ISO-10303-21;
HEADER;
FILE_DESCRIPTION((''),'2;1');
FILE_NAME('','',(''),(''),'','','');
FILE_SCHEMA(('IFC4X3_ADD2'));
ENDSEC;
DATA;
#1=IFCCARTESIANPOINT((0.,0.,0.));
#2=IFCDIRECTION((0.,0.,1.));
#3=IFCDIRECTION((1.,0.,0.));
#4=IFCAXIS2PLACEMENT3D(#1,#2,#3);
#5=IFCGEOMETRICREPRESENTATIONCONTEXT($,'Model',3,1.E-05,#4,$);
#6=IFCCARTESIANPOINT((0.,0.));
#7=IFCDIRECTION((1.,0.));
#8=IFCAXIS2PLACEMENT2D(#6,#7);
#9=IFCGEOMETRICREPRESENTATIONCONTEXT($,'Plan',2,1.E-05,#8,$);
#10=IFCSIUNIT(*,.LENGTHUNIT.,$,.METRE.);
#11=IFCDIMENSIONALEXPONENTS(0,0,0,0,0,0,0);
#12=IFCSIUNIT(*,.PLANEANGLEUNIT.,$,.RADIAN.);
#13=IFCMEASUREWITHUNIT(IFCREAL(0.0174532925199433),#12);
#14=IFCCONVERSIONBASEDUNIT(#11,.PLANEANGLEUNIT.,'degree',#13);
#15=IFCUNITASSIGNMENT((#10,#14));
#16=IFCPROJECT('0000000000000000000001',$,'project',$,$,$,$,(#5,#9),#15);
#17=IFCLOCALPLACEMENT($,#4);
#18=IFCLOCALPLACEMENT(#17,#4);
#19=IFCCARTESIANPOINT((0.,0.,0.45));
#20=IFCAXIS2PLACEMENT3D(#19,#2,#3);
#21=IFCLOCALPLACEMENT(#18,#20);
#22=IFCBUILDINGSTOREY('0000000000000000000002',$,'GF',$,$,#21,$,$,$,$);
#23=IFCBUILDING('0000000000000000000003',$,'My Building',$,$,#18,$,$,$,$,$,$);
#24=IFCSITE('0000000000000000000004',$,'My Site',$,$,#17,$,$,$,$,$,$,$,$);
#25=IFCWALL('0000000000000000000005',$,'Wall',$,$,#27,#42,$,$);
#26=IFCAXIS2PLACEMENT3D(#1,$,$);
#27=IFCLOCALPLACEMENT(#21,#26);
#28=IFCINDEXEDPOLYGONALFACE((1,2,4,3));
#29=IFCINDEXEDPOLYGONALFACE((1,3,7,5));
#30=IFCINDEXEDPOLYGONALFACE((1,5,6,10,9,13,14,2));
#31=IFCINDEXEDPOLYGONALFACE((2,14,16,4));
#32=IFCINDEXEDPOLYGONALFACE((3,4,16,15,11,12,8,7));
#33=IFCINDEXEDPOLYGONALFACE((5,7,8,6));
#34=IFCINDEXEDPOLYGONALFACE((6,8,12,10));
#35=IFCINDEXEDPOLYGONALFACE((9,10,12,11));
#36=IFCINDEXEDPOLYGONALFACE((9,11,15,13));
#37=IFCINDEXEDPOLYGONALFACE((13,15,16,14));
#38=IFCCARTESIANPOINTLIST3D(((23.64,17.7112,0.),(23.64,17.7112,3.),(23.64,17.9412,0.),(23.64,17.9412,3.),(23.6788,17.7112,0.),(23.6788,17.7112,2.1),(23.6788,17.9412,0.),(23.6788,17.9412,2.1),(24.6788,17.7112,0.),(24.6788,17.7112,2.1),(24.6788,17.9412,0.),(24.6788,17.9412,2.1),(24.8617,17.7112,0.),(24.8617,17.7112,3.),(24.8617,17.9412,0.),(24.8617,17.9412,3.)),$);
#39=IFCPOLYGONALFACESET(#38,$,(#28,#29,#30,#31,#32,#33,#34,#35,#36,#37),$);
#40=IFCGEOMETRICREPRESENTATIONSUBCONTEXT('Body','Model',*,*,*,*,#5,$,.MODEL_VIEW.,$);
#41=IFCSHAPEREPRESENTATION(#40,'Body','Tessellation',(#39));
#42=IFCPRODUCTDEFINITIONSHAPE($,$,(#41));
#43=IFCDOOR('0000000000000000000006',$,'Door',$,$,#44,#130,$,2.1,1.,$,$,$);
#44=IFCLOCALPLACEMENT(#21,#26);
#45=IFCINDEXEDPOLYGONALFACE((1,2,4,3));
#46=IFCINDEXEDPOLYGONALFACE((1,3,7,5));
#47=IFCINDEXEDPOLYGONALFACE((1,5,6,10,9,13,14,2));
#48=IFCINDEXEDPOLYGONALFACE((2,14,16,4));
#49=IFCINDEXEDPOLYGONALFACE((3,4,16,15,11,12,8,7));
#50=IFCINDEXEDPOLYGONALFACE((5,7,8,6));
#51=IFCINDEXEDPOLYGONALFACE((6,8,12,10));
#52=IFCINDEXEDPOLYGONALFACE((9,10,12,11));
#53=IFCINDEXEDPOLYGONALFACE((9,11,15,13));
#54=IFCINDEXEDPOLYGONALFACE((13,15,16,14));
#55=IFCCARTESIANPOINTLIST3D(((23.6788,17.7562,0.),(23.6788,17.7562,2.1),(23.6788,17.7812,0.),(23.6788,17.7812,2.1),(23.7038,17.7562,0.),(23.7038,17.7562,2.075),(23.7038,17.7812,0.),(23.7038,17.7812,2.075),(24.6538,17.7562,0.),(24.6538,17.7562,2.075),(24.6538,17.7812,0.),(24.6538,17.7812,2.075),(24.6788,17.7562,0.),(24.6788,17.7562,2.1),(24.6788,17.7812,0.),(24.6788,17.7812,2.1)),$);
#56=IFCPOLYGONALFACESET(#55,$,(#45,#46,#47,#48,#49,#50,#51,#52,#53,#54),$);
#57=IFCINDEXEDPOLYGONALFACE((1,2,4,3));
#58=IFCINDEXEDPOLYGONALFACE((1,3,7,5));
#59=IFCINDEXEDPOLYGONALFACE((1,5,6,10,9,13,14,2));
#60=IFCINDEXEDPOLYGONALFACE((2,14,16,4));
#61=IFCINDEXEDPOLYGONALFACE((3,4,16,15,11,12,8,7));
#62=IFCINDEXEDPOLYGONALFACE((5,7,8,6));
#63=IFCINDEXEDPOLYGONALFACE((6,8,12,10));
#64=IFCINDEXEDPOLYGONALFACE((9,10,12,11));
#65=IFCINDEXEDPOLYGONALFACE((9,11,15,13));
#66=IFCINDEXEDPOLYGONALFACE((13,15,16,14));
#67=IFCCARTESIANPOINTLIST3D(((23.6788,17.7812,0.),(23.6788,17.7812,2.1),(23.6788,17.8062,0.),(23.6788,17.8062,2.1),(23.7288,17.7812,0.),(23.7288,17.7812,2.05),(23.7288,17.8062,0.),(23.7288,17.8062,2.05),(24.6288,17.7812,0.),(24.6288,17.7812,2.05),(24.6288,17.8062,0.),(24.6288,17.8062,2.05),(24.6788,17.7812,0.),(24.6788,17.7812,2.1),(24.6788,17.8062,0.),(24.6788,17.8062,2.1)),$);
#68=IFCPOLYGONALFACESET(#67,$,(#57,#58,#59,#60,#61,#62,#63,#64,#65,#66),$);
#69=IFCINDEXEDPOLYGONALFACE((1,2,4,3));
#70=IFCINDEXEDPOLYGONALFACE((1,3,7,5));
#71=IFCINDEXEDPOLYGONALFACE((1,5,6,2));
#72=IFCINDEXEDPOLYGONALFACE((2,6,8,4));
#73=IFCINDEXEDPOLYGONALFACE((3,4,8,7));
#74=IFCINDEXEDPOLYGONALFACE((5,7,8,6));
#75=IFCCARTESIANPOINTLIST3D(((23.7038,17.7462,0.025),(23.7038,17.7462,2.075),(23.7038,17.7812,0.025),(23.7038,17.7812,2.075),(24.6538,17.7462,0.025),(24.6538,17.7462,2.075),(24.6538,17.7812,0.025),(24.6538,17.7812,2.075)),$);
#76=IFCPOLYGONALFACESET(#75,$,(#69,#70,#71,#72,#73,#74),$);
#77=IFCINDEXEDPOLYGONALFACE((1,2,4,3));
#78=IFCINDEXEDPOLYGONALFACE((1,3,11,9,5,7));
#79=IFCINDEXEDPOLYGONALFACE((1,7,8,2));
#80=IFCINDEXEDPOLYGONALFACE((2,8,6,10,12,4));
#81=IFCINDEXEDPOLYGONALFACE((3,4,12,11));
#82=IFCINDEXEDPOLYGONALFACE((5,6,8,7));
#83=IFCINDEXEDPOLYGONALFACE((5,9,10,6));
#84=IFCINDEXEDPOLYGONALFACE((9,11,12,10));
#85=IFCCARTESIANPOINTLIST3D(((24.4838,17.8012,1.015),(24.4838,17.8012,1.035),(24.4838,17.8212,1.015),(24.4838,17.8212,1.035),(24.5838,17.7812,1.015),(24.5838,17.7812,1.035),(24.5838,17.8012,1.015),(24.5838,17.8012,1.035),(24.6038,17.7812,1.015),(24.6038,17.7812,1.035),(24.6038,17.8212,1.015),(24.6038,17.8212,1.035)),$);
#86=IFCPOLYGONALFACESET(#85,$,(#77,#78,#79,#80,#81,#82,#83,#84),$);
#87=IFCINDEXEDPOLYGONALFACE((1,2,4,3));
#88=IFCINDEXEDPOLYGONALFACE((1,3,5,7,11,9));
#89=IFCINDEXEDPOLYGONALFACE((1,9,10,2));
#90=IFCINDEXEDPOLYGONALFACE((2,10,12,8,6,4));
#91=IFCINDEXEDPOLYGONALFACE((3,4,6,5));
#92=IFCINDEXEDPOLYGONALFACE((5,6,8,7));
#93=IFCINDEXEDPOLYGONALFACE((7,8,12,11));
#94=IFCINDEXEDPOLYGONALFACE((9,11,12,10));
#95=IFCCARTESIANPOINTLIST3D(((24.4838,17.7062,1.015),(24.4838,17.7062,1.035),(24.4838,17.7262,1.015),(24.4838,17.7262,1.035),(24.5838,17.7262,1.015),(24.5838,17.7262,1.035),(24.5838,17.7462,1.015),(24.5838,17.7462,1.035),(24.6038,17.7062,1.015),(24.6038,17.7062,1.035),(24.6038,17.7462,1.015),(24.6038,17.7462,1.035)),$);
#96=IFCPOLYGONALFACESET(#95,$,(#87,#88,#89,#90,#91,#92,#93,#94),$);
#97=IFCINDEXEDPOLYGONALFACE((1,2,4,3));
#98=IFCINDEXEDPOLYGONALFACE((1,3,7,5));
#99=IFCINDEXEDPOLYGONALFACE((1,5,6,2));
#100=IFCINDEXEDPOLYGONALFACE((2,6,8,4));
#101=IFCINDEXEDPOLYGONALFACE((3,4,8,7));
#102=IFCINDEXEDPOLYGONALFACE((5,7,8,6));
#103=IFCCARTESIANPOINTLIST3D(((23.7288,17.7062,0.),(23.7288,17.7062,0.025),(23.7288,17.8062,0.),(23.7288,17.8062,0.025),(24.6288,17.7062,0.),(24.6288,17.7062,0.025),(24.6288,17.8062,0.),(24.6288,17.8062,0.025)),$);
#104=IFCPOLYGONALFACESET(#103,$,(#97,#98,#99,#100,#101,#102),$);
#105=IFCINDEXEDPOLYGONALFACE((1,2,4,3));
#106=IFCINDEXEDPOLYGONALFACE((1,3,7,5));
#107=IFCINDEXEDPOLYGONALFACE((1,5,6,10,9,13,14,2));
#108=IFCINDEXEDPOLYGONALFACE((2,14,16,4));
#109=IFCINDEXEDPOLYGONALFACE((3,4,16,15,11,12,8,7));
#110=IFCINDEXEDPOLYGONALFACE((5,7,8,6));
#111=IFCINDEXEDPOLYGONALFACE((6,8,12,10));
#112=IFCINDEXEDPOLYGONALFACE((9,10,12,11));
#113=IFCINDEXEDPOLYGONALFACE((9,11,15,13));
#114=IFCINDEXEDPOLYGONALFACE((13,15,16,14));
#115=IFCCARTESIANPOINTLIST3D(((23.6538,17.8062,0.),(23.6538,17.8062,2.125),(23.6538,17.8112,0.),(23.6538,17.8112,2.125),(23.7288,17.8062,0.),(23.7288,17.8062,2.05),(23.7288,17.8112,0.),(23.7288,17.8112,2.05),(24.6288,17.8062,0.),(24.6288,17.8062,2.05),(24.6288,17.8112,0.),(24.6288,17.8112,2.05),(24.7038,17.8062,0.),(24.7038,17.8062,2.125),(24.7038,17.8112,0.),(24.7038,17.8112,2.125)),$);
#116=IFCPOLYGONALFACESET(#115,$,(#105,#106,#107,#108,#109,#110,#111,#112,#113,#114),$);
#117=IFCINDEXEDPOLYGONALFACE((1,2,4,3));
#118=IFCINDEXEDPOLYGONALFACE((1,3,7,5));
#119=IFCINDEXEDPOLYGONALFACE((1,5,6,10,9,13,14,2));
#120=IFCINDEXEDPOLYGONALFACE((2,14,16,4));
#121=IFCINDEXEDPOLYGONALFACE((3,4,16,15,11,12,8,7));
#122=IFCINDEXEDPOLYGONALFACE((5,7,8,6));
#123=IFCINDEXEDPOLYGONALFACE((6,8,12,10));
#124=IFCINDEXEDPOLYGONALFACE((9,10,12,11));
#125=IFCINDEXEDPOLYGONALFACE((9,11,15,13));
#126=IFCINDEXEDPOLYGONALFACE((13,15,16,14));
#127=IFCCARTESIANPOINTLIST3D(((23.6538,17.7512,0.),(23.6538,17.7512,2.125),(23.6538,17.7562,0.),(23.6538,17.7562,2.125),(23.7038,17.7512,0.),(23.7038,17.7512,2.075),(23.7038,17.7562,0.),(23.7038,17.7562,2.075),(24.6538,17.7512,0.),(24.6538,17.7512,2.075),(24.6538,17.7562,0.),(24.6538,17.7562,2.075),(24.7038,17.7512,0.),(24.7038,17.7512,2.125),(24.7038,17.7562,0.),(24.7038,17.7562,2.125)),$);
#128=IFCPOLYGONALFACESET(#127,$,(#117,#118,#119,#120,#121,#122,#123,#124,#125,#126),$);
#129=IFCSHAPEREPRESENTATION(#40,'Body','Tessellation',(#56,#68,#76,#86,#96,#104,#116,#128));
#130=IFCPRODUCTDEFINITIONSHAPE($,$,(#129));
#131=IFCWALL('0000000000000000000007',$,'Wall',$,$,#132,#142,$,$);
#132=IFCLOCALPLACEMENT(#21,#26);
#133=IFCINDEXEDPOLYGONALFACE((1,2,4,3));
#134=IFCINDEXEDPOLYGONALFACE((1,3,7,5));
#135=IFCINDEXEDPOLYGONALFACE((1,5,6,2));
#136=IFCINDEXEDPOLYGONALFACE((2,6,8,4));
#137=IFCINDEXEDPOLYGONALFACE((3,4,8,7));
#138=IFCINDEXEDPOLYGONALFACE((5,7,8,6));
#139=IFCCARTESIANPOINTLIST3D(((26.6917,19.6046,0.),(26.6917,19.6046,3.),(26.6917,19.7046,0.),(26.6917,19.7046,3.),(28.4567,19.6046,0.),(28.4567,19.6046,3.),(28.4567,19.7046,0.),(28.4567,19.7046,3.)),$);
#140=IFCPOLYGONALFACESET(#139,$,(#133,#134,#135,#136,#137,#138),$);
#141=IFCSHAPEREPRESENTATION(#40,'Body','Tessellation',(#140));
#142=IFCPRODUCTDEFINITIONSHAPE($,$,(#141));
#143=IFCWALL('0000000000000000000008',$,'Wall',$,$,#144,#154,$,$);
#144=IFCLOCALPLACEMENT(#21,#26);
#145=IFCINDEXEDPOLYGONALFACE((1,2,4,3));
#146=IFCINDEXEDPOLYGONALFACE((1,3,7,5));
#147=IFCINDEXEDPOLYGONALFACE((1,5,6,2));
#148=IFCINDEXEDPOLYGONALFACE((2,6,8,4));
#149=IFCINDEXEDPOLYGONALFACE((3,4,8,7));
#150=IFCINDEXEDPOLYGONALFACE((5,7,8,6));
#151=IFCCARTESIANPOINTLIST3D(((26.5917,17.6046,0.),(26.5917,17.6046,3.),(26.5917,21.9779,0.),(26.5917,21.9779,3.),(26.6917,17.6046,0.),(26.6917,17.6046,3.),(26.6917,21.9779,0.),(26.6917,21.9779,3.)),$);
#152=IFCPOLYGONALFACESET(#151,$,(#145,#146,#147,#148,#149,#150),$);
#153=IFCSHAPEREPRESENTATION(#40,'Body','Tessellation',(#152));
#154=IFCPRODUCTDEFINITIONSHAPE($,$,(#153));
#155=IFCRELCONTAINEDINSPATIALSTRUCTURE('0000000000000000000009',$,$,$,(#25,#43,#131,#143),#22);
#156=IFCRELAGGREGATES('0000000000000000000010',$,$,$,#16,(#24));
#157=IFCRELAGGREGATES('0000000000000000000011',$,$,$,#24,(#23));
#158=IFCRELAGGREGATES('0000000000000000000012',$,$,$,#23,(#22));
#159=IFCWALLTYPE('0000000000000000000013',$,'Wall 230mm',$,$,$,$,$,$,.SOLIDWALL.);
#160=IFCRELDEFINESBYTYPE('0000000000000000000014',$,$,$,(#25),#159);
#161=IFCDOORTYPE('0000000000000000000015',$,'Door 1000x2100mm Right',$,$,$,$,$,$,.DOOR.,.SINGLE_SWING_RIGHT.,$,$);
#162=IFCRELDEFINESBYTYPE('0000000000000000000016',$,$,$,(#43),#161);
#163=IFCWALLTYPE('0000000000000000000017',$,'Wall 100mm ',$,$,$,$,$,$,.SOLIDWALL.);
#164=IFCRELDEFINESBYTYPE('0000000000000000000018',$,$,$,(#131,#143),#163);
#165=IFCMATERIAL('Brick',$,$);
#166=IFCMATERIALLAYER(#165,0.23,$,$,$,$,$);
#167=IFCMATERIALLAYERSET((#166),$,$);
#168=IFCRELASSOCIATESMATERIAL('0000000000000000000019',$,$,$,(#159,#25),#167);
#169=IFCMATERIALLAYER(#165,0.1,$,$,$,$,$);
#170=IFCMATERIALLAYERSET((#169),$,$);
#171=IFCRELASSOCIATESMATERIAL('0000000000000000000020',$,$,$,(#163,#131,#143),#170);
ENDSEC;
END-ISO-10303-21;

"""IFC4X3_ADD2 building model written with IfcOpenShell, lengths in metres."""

from ifc_helpers import new_model, entity, si_unit, converted_unit, frame, origin_with_axes, origin_2d_with_axis, place, context, subcontext, project, spatial, line, indexed_curve, outline, extrude, shape, source, transform, mapped, material, layer, layer_set, layer_usage, type_object, type_shapes, element, fill, save


model = new_model("IFC4X3_ADD2")

# Units and contexts
model_context = context("Model", 3, precision=1e-05, world=origin_with_axes())
plan_context = context("Plan", 2, precision=1e-05, world=origin_2d_with_axis())
body_context_1 = subcontext(model_context, "Body", "Model", "MODEL_VIEW")
body_context_2 = subcontext(plan_context, "Body", "Plan", "PLAN_VIEW")
ifc_project = project(units=[si_unit("LENGTHUNIT", "METRE"), converted_unit("PLANEANGLEUNIT", "degree", entity("IfcReal", 0.0174532925199433), si_unit("PLANEANGLEUNIT", "RADIAN"), dimensions=[0, 0, 0, 0, 0, 0, 0])], contexts=[model_context, plan_context])

# Site, building, storey
site_placement = place(None, origin_with_axes())
site = spatial("IfcSite", under=ifc_project, at=site_placement, Name="My Site")
building_placement = place(site_placement, origin_with_axes())
building = spatial("IfcBuilding", under=site, at=building_placement, Name="My Building")
storey_placement = place(building_placement, frame((0.0, 0.0, 0.45), z_axis=(0.0, 0.0, 1.0), x_axis=(1.0, 0.0, 0.0)))
storey = spatial("IfcBuildingStorey", under=building, at=storey_placement, Name="GF")

# Shared definitions
ifc_material_1 = material(Name="Brick")
ifc_layer_1 = layer(ifc_material_1, 0.23)
ifc_layer_set_1 = layer_set([ifc_layer_1])
wall_type_1 = type_object("IfcWallType", Name="Wall 230mm", PredefinedType="SOLIDWALL", material=ifc_layer_set_1)

# Wall, opening, door
ifc_layer_usage_1 = layer_usage(ifc_layer_set_1, "AXIS2", "POSITIVE", 0.0)
wall_1_placement = place(storey_placement, frame((23.64, 17.7112, 0.0), z_axis=(0.0, 0.0, 1.0), x_axis=(1.0, 0.0, 0.0)))
wall_1 = element("IfcWall", 1, at=wall_1_placement, inside=storey, type_object=wall_type_1, material=ifc_layer_usage_1, Name="Wall", context=body_context_1, shape_type="SweptSolid", body=[
    extrude(outline(indexed_curve([(0.0, 0.0), (0.0, 0.23), (1.2216, 0.23), (1.2216, 0.0), (0.0, 0.0)], self_intersect=False)), origin_with_axes(), (0.0, 0.0, 1.0), 3.0),
])
shared_shape_1 = source(origin_with_axes(), body_context_1, "Body", "SweptSolid", [
    extrude(outline(indexed_curve([(0.0, 0.0), (1.0, 0.0), (1.0, 2.1), (0.0, 2.1)], segments=[line(1, 2, 3, 4, 1)])), frame((0.0, -0.6, 0.0), z_axis=(0.0, -1.0, 0.0), x_axis=(1.0, 0.0, 0.0)), (0.0, 0.0, -1.0), 1.2),
])
opening_1_placement = place(wall_1_placement, frame((1.0387, 0.095, 0.0), z_axis=(0.0, 0.0, 1.0), x_axis=(-1.0, 0.0, 0.0)))
opening_1 = element("IfcOpeningElement", 2, at=opening_1_placement, cuts=wall_1, PredefinedType="OPENING", context=body_context_1, shape_type="MappedRepresentation", body=[
    mapped(shared_shape_1, transform((0.0, 0.0, 0.0), x_axis=(1.0, 0.0, 0.0), y_axis=(0.0, 1.0, 0.0), z_axis=(0.0, 0.0, 1.0), scale=1.0)),
])
door_type = type_object("IfcDoorType", Name="Door 1000x2100mm Right", OperationType="SINGLE_SWING_RIGHT", PredefinedType="DOOR")
shared_shape_2 = source(origin_with_axes(), body_context_1, "Body", "SweptSolid", [
    extrude(outline(indexed_curve([(0.0, 0.0), (0.0, 2.1), (1.0, 2.1), (1.0, 0.0), (0.975, 0.0), (0.975, 2.075), (0.025, 2.075), (0.025, 0.0)], segments=[line(1, 2, 3, 4, 5, 6, 7, 8, 1)])), frame((0.0, 0.025, 0.0), z_axis=(0.0, -1.0, 0.0), x_axis=(1.0, 0.0, 0.0)), (0.0, 0.0, -1.0), 0.025),
    extrude(outline(indexed_curve([(0.0, 0.0), (0.0, 2.1), (1.0, 2.1), (1.0, 0.0), (0.95, 0.0), (0.95, 2.05), (0.05, 2.05), (0.05, 0.0)], segments=[line(1, 2, 3, 4, 5, 6, 7, 8, 1)])), frame((0.0, 0.0, 0.0), z_axis=(0.0, -1.0, 0.0), x_axis=(1.0, 0.0, 0.0)), (0.0, 0.0, -1.0), 0.025),
    extrude(outline(indexed_curve([(0.0, 0.0), (0.95, 0.0), (0.95, 0.035), (0.0, 0.035)], segments=[line(1, 2, 3, 4, 1)])), frame((0.025, 0.025, 0.025), z_axis=(0.0, 0.0, 1.0), x_axis=(1.0, 0.0, 0.0)), (0.0, 0.0, 1.0), 2.05),
    extrude(outline(indexed_curve([(0.0, 0.0), (0.0, -0.04), (0.12, -0.04), (0.12, -0.02), (0.02, -0.02), (0.02, 0.0)], segments=[line(1, 2, 3, 4, 5, 6, 1)])), frame((0.075, 0.025, 1.015), z_axis=(0.0, 0.0, 1.0), x_axis=(1.0, 0.0, 0.0)), (0.0, 0.0, 1.0), 0.02),
    extrude(outline(indexed_curve([(0.0, 0.0), (0.0, 0.04), (0.12, 0.04), (0.12, 0.02), (0.02, 0.02), (0.02, 0.0)], segments=[line(1, 2, 3, 4, 5, 6, 1)])), frame((0.075, 0.06, 1.015), z_axis=(0.0, 0.0, 1.0), x_axis=(1.0, 0.0, 0.0)), (0.0, 0.0, 1.0), 0.02),
    extrude(outline(indexed_curve([(0.0, 0.0), (0.9, 0.0), (0.9, 0.1), (0.0, 0.1)], segments=[line(1, 2, 3, 4, 1)])), frame((0.05, 0.0, 0.0), z_axis=(0.0, 0.0, 1.0), x_axis=(1.0, 0.0, 0.0)), (0.0, 0.0, 1.0), 0.025),
    extrude(outline(indexed_curve([(0.0, 0.0), (0.0, 2.125), (1.05, 2.125), (1.05, 0.0), (0.975, 0.0), (0.975, 2.05), (0.075, 2.05), (0.075, 0.0)], segments=[line(1, 2, 3, 4, 5, 6, 7, 8, 1)])), frame((-0.025, -0.005, 0.0), z_axis=(0.0, -1.0, 0.0), x_axis=(1.0, 0.0, 0.0)), (0.0, 0.0, -1.0), 0.005),
    extrude(outline(indexed_curve([(0.0, 0.0), (0.0, 2.125), (1.05, 2.125), (1.05, 0.0), (1.0, 0.0), (1.0, 2.075), (0.05, 2.075), (0.05, 0.0)], segments=[line(1, 2, 3, 4, 5, 6, 7, 8, 1)])), frame((-0.025, 0.05, 0.0), z_axis=(0.0, -1.0, 0.0), x_axis=(1.0, 0.0, 0.0)), (0.0, 0.0, -1.0), 0.005),
])
shared_shape_3 = source(origin_with_axes(), body_context_2, "Body", "Curve2D", [
    entity("IfcIndexedPolyCurve", entity("IfcCartesianPointList2D", [[0.0, 0.0], [0.0, 0.05], [0.025, 0.05], [0.025, 0.025], [0.05, 0.025], [0.05, 0.0]]), [entity("IfcLineIndex", [1, 2, 3, 4, 5, 6, 1])]),
    entity("IfcIndexedPolyCurve", entity("IfcCartesianPointList2D", [[1.0, 0.0], [1.0, 0.05], [0.975, 0.05], [0.975, 0.025], [0.95, 0.025], [0.95, 0.0]]), [entity("IfcLineIndex", [1, 2, 3, 4, 5, 6, 1])]),
    entity("IfcTrimmedCurve", entity("IfcEllipse", entity("IfcAxis2Placement2D", entity("IfcCartesianPoint", [0.94, 0.05]), entity("IfcDirection", [1.0, 0.0])), 0.915, 0.95), [entity("IfcCartesianPoint", [0.94, 1.0])], [entity("IfcCartesianPoint", [0.025, 0.05])], True, "CARTESIAN"),
    entity("IfcIndexedPolyCurve", entity("IfcCartesianPointList2D", [[0.975, 0.05], [0.94, 0.05], [0.94, 1.0], [0.975, 1.0]]), [entity("IfcLineIndex", [1, 2, 3, 4, 1])]),
])
type_shapes(door_type, [shared_shape_2, shared_shape_3])
door_placement = place(opening_1_placement, origin_with_axes())
door = element("IfcDoor", 3, at=door_placement, inside=storey, type_object=door_type, Name="Door", OverallHeight=2.1, OverallWidth=1.0, shapes=[
    shape(body_context_1, "Body", "MappedRepresentation", [mapped(shared_shape_2, transform((0.0, 0.0, 0.0), x_axis=(1.0, 0.0, 0.0), y_axis=(0.0, 1.0, 0.0), z_axis=(0.0, 0.0, 1.0), scale=1.0))]),
    shape(body_context_2, "Body", "MappedRepresentation", [mapped(shared_shape_3, transform((0.0, 0.0, 0.0), x_axis=(1.0, 0.0, 0.0), y_axis=(0.0, 1.0, 0.0), z_axis=(0.0, 0.0, 1.0), scale=1.0))]),
])
fill(opening_1, door)

# Walls
ifc_layer_2 = layer(ifc_material_1, 0.1)
ifc_layer_set_2 = layer_set([ifc_layer_2])
ifc_layer_usage_2 = layer_usage(ifc_layer_set_2, "AXIS2", "POSITIVE", 0.0)
wall_type_2 = type_object("IfcWallType", Name="Wall 100mm ", PredefinedType="SOLIDWALL", material=ifc_layer_set_2)
wall_2_placement = place(storey_placement, frame((26.6917, 19.6046, 0.0), z_axis=(0.0, 0.0, 1.0), x_axis=(1.0, 0.0, 0.0)))
element("IfcWall", 4, at=wall_2_placement, inside=storey, type_object=wall_type_2, material=ifc_layer_usage_2, Name="Wall", context=body_context_1, shape_type="SweptSolid", body=[
    extrude(outline(indexed_curve([(0.0, 0.0), (0.0, 0.1), (1.765, 0.1), (1.765, 0.0), (0.0, 0.0)], self_intersect=False)), origin_with_axes(), (0.0, 0.0, 1.0), 3.0),
])
ifc_layer_usage_3 = layer_usage(ifc_layer_set_2, "AXIS2", "POSITIVE", 0.0)
wall_3_placement = place(storey_placement, frame((26.6917, 17.6046, 0.0), z_axis=(0.0, 0.0, 1.0), x_axis=(0.0, 1.0, 0.0)))
element("IfcWall", 5, at=wall_3_placement, inside=storey, type_object=wall_type_2, material=ifc_layer_usage_3, Name="Wall", context=body_context_1, shape_type="SweptSolid", body=[
    extrude(outline(indexed_curve([(0.0, 0.0), (0.0, 0.1), (4.3733, 0.1), (4.3733, 0.0), (0.0, 0.0)], self_intersect=False)), origin_with_axes(), (0.0, 0.0, 1.0), 3.0),
])

save(model, "model.ifc")
